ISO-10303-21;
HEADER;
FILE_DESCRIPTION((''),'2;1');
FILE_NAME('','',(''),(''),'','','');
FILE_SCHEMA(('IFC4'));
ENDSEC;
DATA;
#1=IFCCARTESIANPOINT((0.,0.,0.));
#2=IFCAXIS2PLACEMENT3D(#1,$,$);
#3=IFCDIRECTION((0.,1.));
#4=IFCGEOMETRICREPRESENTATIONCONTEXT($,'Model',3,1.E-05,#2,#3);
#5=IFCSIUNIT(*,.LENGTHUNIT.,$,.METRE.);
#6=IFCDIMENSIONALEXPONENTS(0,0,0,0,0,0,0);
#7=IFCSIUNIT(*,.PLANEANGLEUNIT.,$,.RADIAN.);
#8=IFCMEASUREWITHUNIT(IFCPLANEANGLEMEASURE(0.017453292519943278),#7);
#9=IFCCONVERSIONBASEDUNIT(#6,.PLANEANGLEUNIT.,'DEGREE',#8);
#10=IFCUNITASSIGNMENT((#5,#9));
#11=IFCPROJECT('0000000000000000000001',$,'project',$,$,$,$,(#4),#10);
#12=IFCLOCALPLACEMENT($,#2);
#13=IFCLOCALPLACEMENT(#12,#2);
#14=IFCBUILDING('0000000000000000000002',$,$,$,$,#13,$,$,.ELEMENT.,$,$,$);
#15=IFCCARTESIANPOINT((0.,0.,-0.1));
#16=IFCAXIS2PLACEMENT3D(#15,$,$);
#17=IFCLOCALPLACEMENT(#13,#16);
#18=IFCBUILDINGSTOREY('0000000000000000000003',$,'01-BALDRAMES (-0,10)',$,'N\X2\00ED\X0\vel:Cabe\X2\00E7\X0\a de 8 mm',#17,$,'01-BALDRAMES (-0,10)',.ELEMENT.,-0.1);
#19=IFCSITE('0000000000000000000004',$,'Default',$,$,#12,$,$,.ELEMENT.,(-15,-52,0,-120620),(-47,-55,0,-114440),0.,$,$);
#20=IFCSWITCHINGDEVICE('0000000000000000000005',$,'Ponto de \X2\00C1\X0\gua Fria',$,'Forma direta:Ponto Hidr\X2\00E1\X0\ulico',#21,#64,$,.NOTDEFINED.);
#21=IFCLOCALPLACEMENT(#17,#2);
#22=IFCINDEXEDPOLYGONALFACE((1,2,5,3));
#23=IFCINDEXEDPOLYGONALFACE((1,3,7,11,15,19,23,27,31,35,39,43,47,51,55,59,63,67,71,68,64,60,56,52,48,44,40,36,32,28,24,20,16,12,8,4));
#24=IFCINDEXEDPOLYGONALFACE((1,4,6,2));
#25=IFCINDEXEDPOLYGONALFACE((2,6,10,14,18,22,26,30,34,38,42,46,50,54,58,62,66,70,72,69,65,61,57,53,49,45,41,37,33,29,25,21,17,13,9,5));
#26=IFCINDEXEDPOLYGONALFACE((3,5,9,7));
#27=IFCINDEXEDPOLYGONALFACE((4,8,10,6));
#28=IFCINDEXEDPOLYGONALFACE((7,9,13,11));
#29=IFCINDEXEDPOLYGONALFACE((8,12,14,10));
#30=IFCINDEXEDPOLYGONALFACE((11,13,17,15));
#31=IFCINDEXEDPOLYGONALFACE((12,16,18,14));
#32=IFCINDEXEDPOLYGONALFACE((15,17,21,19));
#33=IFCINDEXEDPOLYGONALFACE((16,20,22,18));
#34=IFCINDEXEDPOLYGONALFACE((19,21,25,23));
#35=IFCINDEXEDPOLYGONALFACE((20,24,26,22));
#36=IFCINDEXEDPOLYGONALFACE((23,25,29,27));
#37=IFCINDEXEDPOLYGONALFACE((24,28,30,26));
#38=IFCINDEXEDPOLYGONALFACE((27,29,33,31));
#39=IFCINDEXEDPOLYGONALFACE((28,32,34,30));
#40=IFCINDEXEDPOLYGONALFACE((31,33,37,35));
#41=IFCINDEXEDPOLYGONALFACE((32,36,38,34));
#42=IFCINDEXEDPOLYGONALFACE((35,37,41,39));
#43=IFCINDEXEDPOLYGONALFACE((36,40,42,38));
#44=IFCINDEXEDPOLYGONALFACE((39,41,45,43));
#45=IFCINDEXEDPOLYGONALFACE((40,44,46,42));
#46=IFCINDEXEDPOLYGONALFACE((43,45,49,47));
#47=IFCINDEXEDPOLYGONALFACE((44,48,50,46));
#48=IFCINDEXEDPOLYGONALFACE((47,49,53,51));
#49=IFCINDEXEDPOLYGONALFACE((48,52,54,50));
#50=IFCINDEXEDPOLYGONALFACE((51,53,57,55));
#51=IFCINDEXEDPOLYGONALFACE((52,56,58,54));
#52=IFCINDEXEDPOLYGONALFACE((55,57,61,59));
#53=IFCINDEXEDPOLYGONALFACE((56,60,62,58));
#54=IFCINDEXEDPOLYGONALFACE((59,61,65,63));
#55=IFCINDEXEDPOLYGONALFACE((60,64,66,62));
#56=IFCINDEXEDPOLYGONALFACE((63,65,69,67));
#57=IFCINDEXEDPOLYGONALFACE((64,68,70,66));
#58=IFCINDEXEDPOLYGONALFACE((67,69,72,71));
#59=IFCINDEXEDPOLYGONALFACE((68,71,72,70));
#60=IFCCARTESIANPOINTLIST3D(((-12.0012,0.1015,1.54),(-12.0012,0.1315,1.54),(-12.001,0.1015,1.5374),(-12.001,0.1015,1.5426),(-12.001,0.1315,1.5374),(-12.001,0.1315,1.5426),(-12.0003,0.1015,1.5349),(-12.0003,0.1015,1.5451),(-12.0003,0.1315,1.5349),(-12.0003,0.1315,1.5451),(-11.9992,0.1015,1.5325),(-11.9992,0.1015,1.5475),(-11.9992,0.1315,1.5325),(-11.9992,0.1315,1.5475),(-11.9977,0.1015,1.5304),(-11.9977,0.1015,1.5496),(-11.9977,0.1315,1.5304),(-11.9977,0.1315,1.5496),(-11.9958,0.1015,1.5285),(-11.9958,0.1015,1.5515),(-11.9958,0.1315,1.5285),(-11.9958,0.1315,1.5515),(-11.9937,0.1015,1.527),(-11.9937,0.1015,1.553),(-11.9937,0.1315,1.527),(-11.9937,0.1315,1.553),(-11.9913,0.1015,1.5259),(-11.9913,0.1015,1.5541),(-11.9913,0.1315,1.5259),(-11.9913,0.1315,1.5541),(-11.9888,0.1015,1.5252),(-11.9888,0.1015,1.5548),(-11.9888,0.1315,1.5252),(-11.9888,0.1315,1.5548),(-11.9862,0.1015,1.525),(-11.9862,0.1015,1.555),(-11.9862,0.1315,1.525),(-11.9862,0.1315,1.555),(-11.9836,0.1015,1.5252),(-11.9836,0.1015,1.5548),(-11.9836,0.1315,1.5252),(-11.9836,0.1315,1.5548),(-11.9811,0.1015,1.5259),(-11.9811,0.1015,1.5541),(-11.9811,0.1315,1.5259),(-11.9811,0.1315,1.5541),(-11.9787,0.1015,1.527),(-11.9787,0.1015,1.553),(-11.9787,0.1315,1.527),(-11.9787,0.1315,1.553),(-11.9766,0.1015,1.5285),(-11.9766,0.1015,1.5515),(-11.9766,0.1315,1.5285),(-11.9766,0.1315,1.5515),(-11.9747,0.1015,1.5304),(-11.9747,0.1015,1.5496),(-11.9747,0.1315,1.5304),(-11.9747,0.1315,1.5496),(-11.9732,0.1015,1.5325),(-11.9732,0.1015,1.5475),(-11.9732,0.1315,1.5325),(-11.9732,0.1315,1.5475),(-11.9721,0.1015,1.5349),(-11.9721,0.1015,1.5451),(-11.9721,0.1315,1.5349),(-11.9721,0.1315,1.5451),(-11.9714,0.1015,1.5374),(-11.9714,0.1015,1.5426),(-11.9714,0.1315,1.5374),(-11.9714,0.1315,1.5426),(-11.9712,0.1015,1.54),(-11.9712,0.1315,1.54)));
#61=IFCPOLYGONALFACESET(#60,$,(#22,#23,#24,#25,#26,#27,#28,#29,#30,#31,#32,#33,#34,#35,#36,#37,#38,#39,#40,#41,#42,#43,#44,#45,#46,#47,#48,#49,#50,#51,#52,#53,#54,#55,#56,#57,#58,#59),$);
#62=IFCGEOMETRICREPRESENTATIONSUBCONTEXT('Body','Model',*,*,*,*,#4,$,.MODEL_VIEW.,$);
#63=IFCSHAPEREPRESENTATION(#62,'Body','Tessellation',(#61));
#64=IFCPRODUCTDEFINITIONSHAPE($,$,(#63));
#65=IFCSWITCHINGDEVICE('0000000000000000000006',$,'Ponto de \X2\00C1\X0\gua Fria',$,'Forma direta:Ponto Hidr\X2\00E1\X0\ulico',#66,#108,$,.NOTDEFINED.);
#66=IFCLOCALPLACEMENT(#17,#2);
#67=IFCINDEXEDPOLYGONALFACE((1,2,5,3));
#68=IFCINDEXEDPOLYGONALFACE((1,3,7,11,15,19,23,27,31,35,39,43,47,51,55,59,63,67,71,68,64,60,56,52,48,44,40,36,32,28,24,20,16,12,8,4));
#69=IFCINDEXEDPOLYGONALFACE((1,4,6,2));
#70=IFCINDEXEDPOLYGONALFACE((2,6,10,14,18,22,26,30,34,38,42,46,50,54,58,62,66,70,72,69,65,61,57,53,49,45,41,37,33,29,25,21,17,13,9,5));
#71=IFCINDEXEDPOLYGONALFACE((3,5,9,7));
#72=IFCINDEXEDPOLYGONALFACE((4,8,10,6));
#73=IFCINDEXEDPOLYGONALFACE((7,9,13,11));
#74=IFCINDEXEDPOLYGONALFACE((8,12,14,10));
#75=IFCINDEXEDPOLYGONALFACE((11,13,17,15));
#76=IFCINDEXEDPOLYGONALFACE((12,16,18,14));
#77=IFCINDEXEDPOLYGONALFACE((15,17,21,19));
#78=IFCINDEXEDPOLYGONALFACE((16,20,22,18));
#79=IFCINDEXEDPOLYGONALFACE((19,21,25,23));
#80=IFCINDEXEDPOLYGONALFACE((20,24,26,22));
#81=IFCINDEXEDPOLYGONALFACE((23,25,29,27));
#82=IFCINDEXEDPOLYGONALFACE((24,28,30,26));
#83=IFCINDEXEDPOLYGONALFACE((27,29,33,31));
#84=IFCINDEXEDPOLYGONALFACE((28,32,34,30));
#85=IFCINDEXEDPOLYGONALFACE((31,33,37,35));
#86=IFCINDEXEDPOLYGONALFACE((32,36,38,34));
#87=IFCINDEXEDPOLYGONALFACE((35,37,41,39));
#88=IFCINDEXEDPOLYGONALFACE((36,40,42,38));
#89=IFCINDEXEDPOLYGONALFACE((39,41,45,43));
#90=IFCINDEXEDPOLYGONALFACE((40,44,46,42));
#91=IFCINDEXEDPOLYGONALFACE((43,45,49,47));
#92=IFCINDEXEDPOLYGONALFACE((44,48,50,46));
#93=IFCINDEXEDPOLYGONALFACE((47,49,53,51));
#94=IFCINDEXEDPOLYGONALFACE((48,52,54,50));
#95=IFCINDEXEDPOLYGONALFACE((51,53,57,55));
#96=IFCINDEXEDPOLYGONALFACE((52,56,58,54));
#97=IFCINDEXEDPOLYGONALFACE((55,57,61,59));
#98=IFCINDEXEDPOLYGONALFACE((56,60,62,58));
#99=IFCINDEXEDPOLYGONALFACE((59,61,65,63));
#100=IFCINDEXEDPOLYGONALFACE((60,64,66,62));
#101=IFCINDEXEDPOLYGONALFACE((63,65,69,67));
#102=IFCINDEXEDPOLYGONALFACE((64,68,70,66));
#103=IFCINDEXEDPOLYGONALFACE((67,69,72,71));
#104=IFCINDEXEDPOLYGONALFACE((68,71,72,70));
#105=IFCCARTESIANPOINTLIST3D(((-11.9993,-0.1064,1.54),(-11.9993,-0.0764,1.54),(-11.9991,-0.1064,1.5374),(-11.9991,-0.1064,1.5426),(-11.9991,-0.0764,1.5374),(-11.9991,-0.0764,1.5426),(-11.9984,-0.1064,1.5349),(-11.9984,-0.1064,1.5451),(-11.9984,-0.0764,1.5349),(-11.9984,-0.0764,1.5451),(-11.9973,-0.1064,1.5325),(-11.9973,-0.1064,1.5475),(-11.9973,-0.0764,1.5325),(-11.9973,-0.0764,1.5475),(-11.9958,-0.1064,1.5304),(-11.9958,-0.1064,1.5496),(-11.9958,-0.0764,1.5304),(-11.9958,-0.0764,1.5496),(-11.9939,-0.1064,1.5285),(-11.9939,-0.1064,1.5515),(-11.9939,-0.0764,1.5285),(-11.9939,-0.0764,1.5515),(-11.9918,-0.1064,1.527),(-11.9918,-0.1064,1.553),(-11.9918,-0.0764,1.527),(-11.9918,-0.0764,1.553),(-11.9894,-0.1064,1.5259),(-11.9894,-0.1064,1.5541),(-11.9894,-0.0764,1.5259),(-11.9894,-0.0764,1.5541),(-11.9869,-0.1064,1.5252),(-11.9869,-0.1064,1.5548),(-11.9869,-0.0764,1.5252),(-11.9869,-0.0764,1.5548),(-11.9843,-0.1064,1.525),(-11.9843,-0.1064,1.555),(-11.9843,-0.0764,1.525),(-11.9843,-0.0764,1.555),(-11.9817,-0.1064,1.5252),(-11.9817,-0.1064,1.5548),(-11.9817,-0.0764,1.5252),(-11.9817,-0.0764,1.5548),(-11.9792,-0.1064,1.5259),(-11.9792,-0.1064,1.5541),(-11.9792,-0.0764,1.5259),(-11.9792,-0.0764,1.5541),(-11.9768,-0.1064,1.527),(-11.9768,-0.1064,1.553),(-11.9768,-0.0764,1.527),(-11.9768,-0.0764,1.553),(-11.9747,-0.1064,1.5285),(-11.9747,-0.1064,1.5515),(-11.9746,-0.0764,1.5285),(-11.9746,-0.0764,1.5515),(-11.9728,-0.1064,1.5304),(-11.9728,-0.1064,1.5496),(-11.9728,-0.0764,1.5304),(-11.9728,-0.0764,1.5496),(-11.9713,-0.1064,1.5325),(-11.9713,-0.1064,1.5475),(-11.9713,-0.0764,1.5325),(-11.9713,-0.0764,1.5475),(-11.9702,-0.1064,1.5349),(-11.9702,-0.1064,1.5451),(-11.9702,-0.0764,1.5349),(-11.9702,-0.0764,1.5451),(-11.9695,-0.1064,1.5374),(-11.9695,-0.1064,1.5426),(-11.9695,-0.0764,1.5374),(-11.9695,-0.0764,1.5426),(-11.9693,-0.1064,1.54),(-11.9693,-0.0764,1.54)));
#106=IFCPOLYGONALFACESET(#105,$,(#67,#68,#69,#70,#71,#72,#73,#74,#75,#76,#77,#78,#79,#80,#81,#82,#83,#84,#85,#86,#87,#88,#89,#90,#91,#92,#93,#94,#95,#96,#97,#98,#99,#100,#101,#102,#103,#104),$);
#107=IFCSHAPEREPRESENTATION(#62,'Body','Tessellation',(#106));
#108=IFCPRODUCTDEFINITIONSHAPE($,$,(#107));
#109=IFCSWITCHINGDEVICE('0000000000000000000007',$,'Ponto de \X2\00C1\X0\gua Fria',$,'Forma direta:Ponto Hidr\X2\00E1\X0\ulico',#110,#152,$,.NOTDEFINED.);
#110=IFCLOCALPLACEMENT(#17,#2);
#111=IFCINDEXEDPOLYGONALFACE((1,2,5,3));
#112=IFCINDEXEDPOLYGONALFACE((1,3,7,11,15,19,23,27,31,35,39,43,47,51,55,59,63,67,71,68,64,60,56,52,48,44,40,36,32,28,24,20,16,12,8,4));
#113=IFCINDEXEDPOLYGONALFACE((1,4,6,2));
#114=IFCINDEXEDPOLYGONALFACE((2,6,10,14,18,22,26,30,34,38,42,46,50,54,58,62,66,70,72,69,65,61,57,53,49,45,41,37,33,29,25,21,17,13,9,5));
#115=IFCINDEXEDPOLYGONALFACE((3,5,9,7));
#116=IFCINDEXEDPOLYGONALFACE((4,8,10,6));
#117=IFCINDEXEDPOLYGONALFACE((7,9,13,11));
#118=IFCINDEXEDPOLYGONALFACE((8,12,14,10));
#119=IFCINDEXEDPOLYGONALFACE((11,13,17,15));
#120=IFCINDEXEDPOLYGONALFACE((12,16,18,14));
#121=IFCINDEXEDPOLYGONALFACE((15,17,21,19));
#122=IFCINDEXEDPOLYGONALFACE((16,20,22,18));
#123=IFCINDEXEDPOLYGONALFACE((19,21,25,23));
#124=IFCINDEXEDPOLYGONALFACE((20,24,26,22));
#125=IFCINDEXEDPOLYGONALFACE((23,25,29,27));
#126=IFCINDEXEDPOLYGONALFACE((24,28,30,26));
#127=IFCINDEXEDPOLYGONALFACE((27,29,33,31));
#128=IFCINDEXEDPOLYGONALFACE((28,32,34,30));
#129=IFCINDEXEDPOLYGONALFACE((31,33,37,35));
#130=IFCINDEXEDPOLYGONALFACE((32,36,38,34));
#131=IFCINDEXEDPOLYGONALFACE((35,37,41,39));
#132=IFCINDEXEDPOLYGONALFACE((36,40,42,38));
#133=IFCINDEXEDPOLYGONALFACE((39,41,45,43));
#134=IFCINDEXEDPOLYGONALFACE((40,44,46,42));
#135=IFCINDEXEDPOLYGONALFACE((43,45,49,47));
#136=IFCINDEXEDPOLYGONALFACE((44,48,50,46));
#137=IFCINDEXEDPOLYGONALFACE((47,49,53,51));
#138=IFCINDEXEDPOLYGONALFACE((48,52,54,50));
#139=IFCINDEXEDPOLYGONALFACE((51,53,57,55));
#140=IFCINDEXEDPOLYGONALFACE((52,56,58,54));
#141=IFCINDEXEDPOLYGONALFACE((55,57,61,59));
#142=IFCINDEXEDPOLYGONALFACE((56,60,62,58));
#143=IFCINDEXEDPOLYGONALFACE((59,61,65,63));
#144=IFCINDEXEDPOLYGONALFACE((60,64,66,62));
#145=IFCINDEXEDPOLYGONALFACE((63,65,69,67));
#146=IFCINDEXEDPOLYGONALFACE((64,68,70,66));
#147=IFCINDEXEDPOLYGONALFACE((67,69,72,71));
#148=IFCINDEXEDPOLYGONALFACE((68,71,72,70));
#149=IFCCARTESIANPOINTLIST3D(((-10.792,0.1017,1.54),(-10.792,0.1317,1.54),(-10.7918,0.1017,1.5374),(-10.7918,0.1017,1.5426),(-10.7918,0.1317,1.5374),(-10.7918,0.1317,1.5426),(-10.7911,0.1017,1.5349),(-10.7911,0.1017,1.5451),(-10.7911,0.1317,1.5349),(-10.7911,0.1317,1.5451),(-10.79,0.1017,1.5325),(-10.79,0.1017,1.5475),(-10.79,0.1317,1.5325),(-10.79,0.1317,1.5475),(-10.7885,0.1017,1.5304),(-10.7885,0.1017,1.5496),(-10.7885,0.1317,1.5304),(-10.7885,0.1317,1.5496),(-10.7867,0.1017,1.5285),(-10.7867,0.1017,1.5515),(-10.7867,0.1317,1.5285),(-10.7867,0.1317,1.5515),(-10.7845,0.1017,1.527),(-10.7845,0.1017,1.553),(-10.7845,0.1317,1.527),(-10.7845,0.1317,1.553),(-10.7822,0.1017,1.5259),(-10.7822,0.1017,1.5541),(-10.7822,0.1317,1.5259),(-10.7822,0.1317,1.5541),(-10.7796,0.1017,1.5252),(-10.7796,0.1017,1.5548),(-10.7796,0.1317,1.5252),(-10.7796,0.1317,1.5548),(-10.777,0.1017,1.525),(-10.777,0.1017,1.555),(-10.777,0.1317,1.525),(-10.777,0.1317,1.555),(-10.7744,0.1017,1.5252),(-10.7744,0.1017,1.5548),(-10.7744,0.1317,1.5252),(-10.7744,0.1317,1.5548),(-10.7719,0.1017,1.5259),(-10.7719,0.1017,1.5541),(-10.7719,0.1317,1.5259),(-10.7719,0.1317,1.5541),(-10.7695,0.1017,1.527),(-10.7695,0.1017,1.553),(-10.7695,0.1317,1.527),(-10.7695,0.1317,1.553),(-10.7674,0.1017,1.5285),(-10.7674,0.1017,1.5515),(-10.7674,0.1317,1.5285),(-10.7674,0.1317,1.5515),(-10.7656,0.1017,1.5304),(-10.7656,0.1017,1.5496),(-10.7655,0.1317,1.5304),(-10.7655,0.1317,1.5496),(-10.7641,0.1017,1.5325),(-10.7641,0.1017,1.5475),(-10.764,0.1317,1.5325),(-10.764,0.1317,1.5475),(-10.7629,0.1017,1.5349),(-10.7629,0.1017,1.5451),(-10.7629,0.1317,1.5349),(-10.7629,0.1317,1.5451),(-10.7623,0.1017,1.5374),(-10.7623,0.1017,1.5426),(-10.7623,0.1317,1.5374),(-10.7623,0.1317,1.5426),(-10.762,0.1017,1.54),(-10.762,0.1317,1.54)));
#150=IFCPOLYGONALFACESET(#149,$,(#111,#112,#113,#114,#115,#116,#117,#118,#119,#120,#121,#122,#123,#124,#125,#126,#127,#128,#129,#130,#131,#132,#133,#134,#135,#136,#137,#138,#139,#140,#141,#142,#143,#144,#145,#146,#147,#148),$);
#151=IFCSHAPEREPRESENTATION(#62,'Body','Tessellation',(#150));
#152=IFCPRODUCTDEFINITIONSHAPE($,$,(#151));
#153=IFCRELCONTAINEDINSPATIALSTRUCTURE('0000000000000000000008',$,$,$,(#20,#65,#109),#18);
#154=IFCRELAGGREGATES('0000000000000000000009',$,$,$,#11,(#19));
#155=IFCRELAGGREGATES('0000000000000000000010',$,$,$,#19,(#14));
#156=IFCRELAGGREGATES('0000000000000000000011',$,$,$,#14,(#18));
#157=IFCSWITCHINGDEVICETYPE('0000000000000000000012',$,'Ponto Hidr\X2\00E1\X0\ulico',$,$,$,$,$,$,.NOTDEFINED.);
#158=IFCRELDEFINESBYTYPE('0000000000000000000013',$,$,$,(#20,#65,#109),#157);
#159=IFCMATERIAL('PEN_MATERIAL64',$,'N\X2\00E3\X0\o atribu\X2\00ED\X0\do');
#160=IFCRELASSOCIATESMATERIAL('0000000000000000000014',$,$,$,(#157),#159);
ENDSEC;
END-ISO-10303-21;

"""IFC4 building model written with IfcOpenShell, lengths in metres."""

from ifc_helpers import new_model, entity, si_unit, converted_unit, direction, frame, origin, place, context, subcontext, project, spatial, indexed_curve, outline, extrude, material, type_object, element, save


model = new_model("IFC4")

# Units and contexts
model_context = context("Model", 3, precision=1e-05, world=origin(), true_north=direction((0.0, 1.0)))
body_context = subcontext(model_context, "Body", "Model", "MODEL_VIEW")
ifc_project = project(units=[si_unit("LENGTHUNIT", "METRE"), converted_unit("PLANEANGLEUNIT", "DEGREE", entity("IfcPlaneAngleMeasure", 0.017453292519943278), si_unit("PLANEANGLEUNIT", "RADIAN"), dimensions=[0, 0, 0, 0, 0, 0, 0])], contexts=[model_context])

# Site, building, storey
site_placement = place(None, origin())
site = spatial("IfcSite", under=ifc_project, at=site_placement, Name="Default", CompositionType="ELEMENT", RefLatitude=(-15, -52, 0, -120620), RefLongitude=(-47, -55, 0, -114440), RefElevation=0.0)
building_placement = place(site_placement, origin())
building = spatial("IfcBuilding", under=site, at=building_placement, CompositionType="ELEMENT")
storey_placement = place(building_placement, frame((0.0, 0.0, -0.1)))
storey = spatial("IfcBuildingStorey", under=building, at=storey_placement, Name="01-BALDRAMES (-0,10)", ObjectType="Nível:Cabeça de 8 mm", LongName="01-BALDRAMES (-0,10)", CompositionType="ELEMENT", Elevation=-0.1)

# Switching devices
ifc_material_1 = material(Name="PEN_MATERIAL64", Category="Não atribuído")
switching_device_type_1 = type_object("IfcSwitchingDeviceType", Name="Ponto Hidráulico", PredefinedType="NOTDEFINED", material=ifc_material_1)
switching_device_1_placement = place(storey_placement, origin())
element("IfcSwitchingDevice", 1, at=switching_device_1_placement, inside=storey, type_object=switching_device_type_1, Name="Ponto de Água Fria", ObjectType="Forma direta:Ponto Hidráulico", PredefinedType="NOTDEFINED", context=body_context, shape_type="SweptSolid", body=[
    extrude(outline(indexed_curve([(-0.0013, -0.0149), (0.0013, -0.0149), (0.0039, -0.0145), (0.0063, -0.0136), (0.0086, -0.0123), (0.0106, -0.0106), (0.0123, -0.0086), (0.0136, -0.0063), (0.0145, -0.0039), (0.0149, -0.0013), (0.0149, 0.0013), (0.0145, 0.0039), (0.0136, 0.0063), (0.0123, 0.0086), (0.0106, 0.0106), (0.0086, 0.0123), (0.0063, 0.0136), (0.0039, 0.0145), (0.0013, 0.0149), (-0.0013, 0.0149), (-0.0039, 0.0145), (-0.0063, 0.0136), (-0.0086, 0.0123), (-0.0106, 0.0106), (-0.0123, 0.0086), (-0.0136, 0.0063), (-0.0145, 0.0039), (-0.0149, 0.0013), (-0.0149, -0.0013), (-0.0145, -0.0039), (-0.0136, -0.0063), (-0.0123, -0.0086), (-0.0106, -0.0106), (-0.0086, -0.0123), (-0.0063, -0.0136), (-0.0039, -0.0145), (-0.0013, -0.0149)], self_intersect=False)), frame((-11.9862, 0.1015, 1.54), z_axis=(0.000299, 1.0, 0.0), x_axis=(-0.996195, 0.000298, -0.087156)), (0.0, 0.0, 1.0), 0.03),
])
switching_device_2_placement = place(storey_placement, origin())
element("IfcSwitchingDevice", 2, at=switching_device_2_placement, inside=storey, type_object=switching_device_type_1, Name="Ponto de Água Fria", ObjectType="Forma direta:Ponto Hidráulico", PredefinedType="NOTDEFINED", context=body_context, shape_type="SweptSolid", body=[
    extrude(outline(indexed_curve([(-0.0013, -0.0149), (0.0013, -0.0149), (0.0039, -0.0145), (0.0063, -0.0136), (0.0086, -0.0123), (0.0106, -0.0106), (0.0123, -0.0086), (0.0136, -0.0063), (0.0145, -0.0039), (0.0149, -0.0013), (0.0149, 0.0013), (0.0145, 0.0039), (0.0136, 0.0063), (0.0123, 0.0086), (0.0106, 0.0106), (0.0086, 0.0123), (0.0063, 0.0136), (0.0039, 0.0145), (0.0013, 0.0149), (-0.0013, 0.0149), (-0.0039, 0.0145), (-0.0063, 0.0136), (-0.0086, 0.0123), (-0.0106, 0.0106), (-0.0123, 0.0086), (-0.0136, 0.0063), (-0.0145, 0.0039), (-0.0149, 0.0013), (-0.0149, -0.0013), (-0.0145, -0.0039), (-0.0136, -0.0063), (-0.0123, -0.0086), (-0.0106, -0.0106), (-0.0086, -0.0123), (-0.0063, -0.0136), (-0.0039, -0.0145), (-0.0013, -0.0149)], self_intersect=False)), frame((-11.9843, -0.1064, 1.54), z_axis=(0.000435, 1.0, 0.0), x_axis=(-0.965926, 0.00042, 0.258819)), (0.0, 0.0, 1.0), 0.03),
])
switching_device_3_placement = place(storey_placement, origin())
element("IfcSwitchingDevice", 3, at=switching_device_3_placement, inside=storey, type_object=switching_device_type_1, Name="Ponto de Água Fria", ObjectType="Forma direta:Ponto Hidráulico", PredefinedType="NOTDEFINED", context=body_context, shape_type="SweptSolid", body=[
    extrude(outline(indexed_curve([(-0.0013, -0.0149), (0.0013, -0.0149), (0.0039, -0.0145), (0.0063, -0.0136), (0.0086, -0.0123), (0.0106, -0.0106), (0.0123, -0.0086), (0.0136, -0.0063), (0.0145, -0.0039), (0.0149, -0.0013), (0.0149, 0.0013), (0.0145, 0.0039), (0.0136, 0.0063), (0.0123, 0.0086), (0.0106, 0.0106), (0.0086, 0.0123), (0.0063, 0.0136), (0.0039, 0.0145), (0.0013, 0.0149), (-0.0013, 0.0149), (-0.0039, 0.0145), (-0.0063, 0.0136), (-0.0086, 0.0123), (-0.0106, 0.0106), (-0.0123, 0.0086), (-0.0136, 0.0063), (-0.0145, 0.0039), (-0.0149, 0.0013), (-0.0149, -0.0013), (-0.0145, -0.0039), (-0.0136, -0.0063), (-0.0123, -0.0086), (-0.0106, -0.0106), (-0.0086, -0.0123), (-0.0063, -0.0136), (-0.0039, -0.0145), (-0.0013, -0.0149)], self_intersect=False)), frame((-10.777, 0.1017, 1.54), z_axis=(0.000299, 1.0, 0.0), x_axis=(-0.996195, 0.000298, -0.087156)), (0.0, 0.0, 1.0), 0.03),
])

save(model, "model.ifc")
